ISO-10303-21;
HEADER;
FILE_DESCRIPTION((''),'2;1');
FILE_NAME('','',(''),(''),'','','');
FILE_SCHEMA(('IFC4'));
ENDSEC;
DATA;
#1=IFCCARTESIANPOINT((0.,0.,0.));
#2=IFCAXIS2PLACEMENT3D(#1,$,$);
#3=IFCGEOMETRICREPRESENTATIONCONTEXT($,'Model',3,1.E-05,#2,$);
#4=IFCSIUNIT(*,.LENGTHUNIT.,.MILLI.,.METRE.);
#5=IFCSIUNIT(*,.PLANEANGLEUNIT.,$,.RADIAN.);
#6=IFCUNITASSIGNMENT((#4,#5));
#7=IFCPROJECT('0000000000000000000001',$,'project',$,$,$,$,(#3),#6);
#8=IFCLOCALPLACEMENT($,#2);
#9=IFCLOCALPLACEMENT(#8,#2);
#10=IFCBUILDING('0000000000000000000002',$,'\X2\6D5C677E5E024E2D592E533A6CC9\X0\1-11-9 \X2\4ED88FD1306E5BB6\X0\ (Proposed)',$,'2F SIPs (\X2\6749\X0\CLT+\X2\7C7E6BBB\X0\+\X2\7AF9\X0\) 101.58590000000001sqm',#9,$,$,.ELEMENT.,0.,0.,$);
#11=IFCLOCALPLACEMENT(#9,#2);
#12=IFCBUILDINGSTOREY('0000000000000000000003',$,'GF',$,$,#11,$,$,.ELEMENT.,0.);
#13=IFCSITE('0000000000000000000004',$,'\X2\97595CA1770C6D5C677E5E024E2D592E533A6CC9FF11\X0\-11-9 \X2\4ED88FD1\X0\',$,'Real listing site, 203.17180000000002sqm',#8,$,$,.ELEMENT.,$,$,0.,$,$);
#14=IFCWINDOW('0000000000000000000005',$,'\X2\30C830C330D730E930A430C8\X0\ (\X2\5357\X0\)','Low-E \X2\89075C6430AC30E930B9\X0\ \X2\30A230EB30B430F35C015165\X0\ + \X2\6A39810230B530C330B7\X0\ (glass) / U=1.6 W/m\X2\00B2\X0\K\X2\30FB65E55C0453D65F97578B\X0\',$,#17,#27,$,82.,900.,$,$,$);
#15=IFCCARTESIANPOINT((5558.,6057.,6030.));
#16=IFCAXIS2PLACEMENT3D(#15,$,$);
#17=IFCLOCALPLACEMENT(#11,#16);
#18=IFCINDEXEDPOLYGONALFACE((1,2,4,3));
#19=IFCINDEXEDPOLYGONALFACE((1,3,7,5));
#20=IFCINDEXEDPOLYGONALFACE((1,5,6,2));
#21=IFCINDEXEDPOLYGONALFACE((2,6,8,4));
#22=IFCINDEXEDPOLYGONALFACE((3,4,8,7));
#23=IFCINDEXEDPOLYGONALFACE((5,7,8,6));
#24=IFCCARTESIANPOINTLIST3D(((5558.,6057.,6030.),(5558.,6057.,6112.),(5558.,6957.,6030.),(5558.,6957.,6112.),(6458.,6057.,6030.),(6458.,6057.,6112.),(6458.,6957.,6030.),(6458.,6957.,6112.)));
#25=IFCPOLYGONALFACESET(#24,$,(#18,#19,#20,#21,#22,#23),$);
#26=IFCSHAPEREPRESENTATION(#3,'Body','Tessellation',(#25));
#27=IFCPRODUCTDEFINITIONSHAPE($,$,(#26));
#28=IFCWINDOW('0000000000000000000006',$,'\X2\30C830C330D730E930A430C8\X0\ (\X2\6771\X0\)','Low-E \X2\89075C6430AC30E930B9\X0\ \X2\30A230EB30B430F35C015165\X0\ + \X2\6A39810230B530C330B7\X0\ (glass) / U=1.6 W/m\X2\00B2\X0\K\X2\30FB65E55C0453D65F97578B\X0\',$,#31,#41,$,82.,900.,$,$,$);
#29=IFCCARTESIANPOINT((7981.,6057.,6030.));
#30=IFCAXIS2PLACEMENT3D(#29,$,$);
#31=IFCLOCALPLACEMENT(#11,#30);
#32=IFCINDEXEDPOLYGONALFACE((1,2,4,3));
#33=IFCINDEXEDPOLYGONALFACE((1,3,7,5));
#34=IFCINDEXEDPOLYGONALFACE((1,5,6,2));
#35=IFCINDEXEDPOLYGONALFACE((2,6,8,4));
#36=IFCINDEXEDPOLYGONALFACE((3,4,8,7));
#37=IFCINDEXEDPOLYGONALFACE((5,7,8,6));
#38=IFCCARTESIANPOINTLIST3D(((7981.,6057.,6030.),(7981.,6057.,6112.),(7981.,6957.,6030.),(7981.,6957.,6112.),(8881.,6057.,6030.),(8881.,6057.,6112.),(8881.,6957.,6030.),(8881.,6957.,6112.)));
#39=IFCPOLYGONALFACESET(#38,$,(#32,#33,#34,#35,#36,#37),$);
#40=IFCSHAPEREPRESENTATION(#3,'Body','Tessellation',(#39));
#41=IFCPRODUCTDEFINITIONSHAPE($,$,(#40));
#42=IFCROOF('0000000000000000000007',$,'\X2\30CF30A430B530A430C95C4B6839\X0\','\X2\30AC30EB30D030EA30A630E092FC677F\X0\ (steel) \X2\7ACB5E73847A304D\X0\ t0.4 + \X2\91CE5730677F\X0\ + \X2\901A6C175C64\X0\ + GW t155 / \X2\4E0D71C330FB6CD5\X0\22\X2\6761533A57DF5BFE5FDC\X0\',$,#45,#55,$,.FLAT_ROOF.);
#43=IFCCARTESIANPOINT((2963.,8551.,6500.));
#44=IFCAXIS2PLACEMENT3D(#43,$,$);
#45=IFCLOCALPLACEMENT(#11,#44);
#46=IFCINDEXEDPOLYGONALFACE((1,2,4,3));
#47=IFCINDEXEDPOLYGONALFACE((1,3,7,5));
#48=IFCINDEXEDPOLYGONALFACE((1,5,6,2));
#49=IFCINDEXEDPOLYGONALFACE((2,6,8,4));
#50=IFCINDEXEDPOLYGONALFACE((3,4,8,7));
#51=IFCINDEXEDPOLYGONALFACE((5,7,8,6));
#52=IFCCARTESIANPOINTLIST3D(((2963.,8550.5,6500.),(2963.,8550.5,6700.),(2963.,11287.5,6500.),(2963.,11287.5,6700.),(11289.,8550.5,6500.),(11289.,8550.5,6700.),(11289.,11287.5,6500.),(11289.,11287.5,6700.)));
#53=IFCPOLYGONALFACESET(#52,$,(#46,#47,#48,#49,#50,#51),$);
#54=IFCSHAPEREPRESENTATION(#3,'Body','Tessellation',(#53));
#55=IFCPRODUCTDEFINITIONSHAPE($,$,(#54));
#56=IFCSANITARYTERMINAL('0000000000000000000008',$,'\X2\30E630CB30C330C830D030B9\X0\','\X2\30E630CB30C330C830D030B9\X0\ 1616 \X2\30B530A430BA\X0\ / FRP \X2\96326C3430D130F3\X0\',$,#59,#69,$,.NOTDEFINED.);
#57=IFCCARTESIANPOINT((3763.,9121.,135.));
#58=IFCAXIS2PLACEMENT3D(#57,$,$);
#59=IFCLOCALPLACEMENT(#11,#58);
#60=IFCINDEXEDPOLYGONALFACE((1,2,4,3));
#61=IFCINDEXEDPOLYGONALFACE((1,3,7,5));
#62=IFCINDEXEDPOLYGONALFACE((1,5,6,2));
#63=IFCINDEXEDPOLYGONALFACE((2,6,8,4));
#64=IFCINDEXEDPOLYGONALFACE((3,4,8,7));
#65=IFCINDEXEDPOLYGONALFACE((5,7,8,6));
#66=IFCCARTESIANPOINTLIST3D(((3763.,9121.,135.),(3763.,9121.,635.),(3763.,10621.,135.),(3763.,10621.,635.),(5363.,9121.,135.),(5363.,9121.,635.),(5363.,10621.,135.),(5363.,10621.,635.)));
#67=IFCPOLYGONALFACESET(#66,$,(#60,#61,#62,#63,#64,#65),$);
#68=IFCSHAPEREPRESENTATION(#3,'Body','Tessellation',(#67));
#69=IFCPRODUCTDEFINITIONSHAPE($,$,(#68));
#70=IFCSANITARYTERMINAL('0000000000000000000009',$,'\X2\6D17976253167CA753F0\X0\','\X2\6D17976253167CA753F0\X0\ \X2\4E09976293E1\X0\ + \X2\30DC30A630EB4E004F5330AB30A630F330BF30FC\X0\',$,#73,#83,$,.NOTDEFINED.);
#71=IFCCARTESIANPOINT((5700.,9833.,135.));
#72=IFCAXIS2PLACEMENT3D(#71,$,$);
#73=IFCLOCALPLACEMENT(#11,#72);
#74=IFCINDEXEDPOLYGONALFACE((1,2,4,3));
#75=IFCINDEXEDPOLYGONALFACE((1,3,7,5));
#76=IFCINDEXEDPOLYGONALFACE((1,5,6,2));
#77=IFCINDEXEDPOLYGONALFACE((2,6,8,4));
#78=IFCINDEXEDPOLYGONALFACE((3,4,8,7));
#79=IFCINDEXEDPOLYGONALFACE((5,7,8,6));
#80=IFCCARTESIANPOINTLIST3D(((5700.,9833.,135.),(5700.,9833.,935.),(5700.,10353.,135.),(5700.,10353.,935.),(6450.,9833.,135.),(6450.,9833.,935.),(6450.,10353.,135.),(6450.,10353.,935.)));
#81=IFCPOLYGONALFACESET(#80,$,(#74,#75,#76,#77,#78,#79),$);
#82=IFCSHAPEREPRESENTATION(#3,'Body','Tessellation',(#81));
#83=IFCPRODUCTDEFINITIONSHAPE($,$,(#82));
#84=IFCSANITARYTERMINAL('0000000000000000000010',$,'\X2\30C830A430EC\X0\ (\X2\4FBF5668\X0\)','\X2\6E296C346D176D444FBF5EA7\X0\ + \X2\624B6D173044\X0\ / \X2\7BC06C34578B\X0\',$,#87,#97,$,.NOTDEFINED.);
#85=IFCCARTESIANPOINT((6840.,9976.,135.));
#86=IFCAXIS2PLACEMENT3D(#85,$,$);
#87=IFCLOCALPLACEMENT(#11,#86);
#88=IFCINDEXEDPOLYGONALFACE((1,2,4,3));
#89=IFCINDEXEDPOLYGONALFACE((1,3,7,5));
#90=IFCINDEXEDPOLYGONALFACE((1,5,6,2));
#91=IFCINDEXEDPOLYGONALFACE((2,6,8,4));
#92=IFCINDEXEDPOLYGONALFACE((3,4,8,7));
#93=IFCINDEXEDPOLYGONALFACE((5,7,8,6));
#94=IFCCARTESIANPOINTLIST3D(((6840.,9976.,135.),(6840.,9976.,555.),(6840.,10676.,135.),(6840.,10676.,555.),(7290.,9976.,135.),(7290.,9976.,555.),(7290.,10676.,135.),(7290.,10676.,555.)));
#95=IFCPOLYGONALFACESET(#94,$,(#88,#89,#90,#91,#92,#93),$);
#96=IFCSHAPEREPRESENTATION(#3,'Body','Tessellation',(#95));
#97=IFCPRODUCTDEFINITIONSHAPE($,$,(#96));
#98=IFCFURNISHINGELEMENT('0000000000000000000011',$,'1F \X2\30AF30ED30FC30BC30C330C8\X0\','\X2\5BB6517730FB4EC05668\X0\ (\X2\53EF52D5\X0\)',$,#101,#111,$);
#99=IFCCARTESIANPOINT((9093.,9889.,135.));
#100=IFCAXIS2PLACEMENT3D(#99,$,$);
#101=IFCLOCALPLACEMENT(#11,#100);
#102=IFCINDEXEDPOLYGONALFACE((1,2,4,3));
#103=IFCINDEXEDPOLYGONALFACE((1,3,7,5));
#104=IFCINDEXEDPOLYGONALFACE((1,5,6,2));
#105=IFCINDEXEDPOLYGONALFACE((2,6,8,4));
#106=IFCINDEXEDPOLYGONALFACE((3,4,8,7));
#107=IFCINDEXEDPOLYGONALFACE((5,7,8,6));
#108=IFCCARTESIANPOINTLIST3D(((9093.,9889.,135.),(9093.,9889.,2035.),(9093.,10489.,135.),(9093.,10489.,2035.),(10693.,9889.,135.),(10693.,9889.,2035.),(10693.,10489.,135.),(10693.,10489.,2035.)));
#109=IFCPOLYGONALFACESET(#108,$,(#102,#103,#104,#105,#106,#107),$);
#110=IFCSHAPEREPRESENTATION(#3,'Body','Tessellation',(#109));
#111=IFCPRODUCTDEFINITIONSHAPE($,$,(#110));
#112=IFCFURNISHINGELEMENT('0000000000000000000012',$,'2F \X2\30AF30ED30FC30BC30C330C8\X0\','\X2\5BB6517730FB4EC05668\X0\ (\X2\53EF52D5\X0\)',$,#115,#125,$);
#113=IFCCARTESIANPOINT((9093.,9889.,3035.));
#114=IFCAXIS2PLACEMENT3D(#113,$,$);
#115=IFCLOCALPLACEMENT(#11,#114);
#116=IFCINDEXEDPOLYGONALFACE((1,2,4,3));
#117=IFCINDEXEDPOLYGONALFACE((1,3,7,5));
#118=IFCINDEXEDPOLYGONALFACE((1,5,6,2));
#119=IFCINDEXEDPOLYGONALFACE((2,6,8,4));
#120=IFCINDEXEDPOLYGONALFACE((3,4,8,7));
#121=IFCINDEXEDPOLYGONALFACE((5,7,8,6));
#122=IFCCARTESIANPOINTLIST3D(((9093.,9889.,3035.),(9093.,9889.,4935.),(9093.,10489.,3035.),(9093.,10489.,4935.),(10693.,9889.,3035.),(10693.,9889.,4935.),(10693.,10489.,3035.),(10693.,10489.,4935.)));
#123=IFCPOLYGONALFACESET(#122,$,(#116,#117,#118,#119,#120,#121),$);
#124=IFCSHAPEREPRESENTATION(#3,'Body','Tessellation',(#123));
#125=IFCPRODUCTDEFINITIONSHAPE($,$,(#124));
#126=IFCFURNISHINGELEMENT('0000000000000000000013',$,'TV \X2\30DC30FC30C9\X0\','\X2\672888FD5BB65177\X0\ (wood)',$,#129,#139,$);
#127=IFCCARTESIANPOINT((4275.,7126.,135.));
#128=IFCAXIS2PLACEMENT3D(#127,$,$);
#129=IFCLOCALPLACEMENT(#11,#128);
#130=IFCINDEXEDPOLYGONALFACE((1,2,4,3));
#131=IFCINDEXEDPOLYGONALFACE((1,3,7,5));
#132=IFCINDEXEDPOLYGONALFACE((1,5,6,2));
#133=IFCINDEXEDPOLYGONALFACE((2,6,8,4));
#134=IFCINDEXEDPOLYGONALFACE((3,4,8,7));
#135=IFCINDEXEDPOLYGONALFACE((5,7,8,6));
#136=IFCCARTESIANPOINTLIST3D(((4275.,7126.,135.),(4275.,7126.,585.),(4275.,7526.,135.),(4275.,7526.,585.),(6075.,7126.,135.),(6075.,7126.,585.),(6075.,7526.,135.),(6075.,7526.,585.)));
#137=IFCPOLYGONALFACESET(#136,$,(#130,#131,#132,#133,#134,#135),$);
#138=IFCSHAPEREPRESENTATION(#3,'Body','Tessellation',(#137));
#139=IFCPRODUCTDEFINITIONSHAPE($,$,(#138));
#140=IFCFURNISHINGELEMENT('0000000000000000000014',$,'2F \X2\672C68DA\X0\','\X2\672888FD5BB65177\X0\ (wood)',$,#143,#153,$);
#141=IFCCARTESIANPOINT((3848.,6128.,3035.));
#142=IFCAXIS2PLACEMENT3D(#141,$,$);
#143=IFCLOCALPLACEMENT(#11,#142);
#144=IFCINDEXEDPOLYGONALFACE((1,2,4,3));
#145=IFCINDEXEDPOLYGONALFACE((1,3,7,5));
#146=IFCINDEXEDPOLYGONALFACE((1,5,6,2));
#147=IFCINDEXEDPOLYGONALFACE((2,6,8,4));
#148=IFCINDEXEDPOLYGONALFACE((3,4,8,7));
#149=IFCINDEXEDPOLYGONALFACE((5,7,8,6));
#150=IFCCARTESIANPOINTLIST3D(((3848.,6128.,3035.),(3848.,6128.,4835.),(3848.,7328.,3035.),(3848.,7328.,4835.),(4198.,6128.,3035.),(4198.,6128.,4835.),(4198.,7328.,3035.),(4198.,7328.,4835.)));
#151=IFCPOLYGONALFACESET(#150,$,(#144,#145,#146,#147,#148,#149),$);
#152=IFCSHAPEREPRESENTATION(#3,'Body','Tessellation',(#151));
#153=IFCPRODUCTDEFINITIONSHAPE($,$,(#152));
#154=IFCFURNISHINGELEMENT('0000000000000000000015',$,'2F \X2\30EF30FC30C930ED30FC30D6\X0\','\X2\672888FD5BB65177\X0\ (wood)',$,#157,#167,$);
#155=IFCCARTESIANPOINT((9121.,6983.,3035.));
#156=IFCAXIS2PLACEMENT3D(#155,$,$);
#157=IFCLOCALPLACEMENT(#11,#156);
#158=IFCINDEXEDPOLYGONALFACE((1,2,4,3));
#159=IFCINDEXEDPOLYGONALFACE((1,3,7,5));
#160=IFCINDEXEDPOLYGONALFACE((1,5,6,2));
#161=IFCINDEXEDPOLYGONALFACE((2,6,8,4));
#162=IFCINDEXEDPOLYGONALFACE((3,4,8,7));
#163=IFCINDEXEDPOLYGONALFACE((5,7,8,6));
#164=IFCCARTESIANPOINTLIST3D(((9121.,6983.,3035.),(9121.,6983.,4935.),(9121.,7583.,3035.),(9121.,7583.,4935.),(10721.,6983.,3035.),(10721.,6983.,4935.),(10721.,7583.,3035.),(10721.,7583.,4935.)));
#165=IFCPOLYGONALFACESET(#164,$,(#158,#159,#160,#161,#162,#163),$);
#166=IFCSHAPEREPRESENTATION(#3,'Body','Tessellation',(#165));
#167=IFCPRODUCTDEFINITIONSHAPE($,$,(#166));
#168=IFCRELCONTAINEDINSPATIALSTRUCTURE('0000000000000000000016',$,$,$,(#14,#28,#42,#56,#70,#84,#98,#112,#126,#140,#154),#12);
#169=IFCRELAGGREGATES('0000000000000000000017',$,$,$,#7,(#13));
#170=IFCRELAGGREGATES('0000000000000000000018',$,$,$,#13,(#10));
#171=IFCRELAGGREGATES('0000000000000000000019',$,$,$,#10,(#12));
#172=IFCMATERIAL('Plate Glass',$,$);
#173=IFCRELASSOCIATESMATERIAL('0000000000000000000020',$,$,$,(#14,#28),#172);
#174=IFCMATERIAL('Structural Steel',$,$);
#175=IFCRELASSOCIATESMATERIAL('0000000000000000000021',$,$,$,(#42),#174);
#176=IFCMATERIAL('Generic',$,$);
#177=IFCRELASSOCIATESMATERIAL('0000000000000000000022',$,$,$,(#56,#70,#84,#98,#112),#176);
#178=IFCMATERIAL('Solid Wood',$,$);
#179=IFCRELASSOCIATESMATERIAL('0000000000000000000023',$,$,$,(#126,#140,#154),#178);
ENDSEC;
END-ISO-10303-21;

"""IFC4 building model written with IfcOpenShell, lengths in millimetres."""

from ifc_helpers import new_model, si_unit, frame, frame_2d, origin, place, context, project, spatial, rectangle, extrude, material, element, save


model = new_model("IFC4")

# Units and contexts
model_context = context("Model", 3, precision=1e-05, world=origin())
ifc_project = project(units=[si_unit("LENGTHUNIT", "METRE", prefix="MILLI"), si_unit("PLANEANGLEUNIT", "RADIAN")], contexts=[model_context])

# Site, building, storey
site_placement = place(None, origin())
site = spatial("IfcSite", under=ifc_project, at=site_placement, Name="静岡県浜松市中央区泉１-11-9 付近", ObjectType="Real listing site, 203.17180000000002sqm", CompositionType="ELEMENT", RefElevation=0.0)
building_placement = place(site_placement, origin())
building = spatial("IfcBuilding", under=site, at=building_placement, Name="浜松市中央区泉1-11-9 付近の家 (Proposed)", ObjectType="2F SIPs (杉CLT+籾殻+竹) 101.58590000000001sqm", CompositionType="ELEMENT", ElevationOfRefHeight=0.0, ElevationOfTerrain=0.0)
storey_placement = place(building_placement, origin())
storey = spatial("IfcBuildingStorey", under=building, at=storey_placement, Name="GF", CompositionType="ELEMENT", Elevation=0.0)

# Shared definitions
ifc_material_1 = material(Name="Solid Wood")
ifc_material_2 = material(Name="Plate Glass")

# Windows
window_1_placement = place(storey_placement, frame((5558.0, 6057.0, 6030.0)))
element("IfcWindow", 1, at=window_1_placement, inside=storey, material=ifc_material_2, Name="トップライト (南)", Description="Low-E 複層ガラス アルゴン封入 + 樹脂サッシ (glass) / U=1.6 W/m²K・日射取得型", OverallHeight=82.0, OverallWidth=900.0, context=model_context, shape_type="SweptSolid", body=[
    extrude(rectangle(XDim=900.0, YDim=900.0, at=frame_2d((450.0, 450.0))), frame((5558.0, 6057.0, 6030.0)), (0.0, 0.0, 1.0), 82.0),
])
window_2_placement = place(storey_placement, frame((7981.0, 6057.0, 6030.0)))
element("IfcWindow", 2, at=window_2_placement, inside=storey, material=ifc_material_2, Name="トップライト (東)", Description="Low-E 複層ガラス アルゴン封入 + 樹脂サッシ (glass) / U=1.6 W/m²K・日射取得型", OverallHeight=82.0, OverallWidth=900.0, context=model_context, shape_type="SweptSolid", body=[
    extrude(rectangle(XDim=900.0, YDim=900.0, at=frame_2d((450.0, 450.0))), frame((7981.0, 6057.0, 6030.0)), (0.0, 0.0, 1.0), 82.0),
])

# Roof
ifc_material_3 = material(Name="Structural Steel")
roof_placement = place(storey_placement, frame((2963.0, 8551.0, 6500.0)))
element("IfcRoof", 3, at=roof_placement, inside=storey, material=ifc_material_3, Name="ハイサイド屋根", Description="ガルバリウム鋼板 (steel) 立平葺き t0.4 + 野地板 + 通気層 + GW t155 / 不燃・法22条区域対応", PredefinedType="FLAT_ROOF", context=model_context, shape_type="SweptSolid", body=[
    extrude(rectangle(XDim=8326.0, YDim=2737.0, at=frame_2d((4163.0, 1368.0))), frame((2963.0, 8551.0, 6500.0)), (0.0, 0.0, 1.0), 200.0),
])

# Sanitary terminals
ifc_material_4 = material(Name="Generic")
sanitary_terminal_1_placement = place(storey_placement, frame((3763.0, 9121.0, 135.0)))
element("IfcSanitaryTerminal", 4, at=sanitary_terminal_1_placement, inside=storey, material=ifc_material_4, Name="ユニットバス", Description="ユニットバス 1616 サイズ / FRP 防水パン", PredefinedType="NOTDEFINED", context=model_context, shape_type="SweptSolid", body=[
    extrude(rectangle(XDim=1600.0, YDim=1500.0, at=frame_2d((800.0, 750.0))), frame((3763.0, 9121.0, 135.0)), (0.0, 0.0, 1.0), 500.0),
])
sanitary_terminal_2_placement = place(storey_placement, frame((5700.0, 9833.0, 135.0)))
element("IfcSanitaryTerminal", 5, at=sanitary_terminal_2_placement, inside=storey, material=ifc_material_4, Name="洗面化粧台", Description="洗面化粧台 三面鏡 + ボウル一体カウンター", PredefinedType="NOTDEFINED", context=model_context, shape_type="SweptSolid", body=[
    extrude(rectangle(XDim=750.0, YDim=520.0, at=frame_2d((375.0, 260.0))), frame((5700.0, 9833.0, 135.0)), (0.0, 0.0, 1.0), 800.0),
])
sanitary_terminal_3_placement = place(storey_placement, frame((6840.0, 9976.0, 135.0)))
element("IfcSanitaryTerminal", 6, at=sanitary_terminal_3_placement, inside=storey, material=ifc_material_4, Name="トイレ (便器)", Description="温水洗浄便座 + 手洗い / 節水型", PredefinedType="NOTDEFINED", context=model_context, shape_type="SweptSolid", body=[
    extrude(rectangle(XDim=450.0, YDim=700.0, at=frame_2d((225.0, 350.0))), frame((6840.0, 9976.0, 135.0)), (0.0, 0.0, 1.0), 420.0),
])

# Furnishing elements
furnishing_1_placement = place(storey_placement, frame((9093.0, 9889.0, 135.0)))
element("IfcFurnishingElement", 7, at=furnishing_1_placement, inside=storey, material=ifc_material_4, Name="1F クローゼット", Description="家具・什器 (可動)", context=model_context, shape_type="SweptSolid", body=[
    extrude(rectangle(XDim=1600.0, YDim=600.0, at=frame_2d((800.0, 300.0))), frame((9093.0, 9889.0, 135.0)), (0.0, 0.0, 1.0), 1900.0),
])
furnishing_2_placement = place(storey_placement, frame((9093.0, 9889.0, 3035.0)))
element("IfcFurnishingElement", 8, at=furnishing_2_placement, inside=storey, material=ifc_material_4, Name="2F クローゼット", Description="家具・什器 (可動)", context=model_context, shape_type="SweptSolid", body=[
    extrude(rectangle(XDim=1600.0, YDim=600.0, at=frame_2d((800.0, 300.0))), frame((9093.0, 9889.0, 3035.0)), (0.0, 0.0, 1.0), 1900.0),
])
furnishing_3_placement = place(storey_placement, frame((4275.0, 7126.0, 135.0)))
element("IfcFurnishingElement", 9, at=furnishing_3_placement, inside=storey, material=ifc_material_1, Name="TV ボード", Description="木製家具 (wood)", context=model_context, shape_type="SweptSolid", body=[
    extrude(rectangle(XDim=1800.0, YDim=400.0, at=frame_2d((900.0, 200.0))), frame((4275.0, 7126.0, 135.0)), (0.0, 0.0, 1.0), 450.0),
])
furnishing_4_placement = place(storey_placement, frame((3848.0, 6128.0, 3035.0)))
element("IfcFurnishingElement", 10, at=furnishing_4_placement, inside=storey, material=ifc_material_1, Name="2F 本棚", Description="木製家具 (wood)", context=model_context, shape_type="SweptSolid", body=[
    extrude(rectangle(XDim=350.0, YDim=1200.0, at=frame_2d((175.0, 600.0))), frame((3848.0, 6128.0, 3035.0)), (0.0, 0.0, 1.0), 1800.0),
])
furnishing_5_placement = place(storey_placement, frame((9121.0, 6983.0, 3035.0)))
element("IfcFurnishingElement", 11, at=furnishing_5_placement, inside=storey, material=ifc_material_1, Name="2F ワードローブ", Description="木製家具 (wood)", context=model_context, shape_type="SweptSolid", body=[
    extrude(rectangle(XDim=1600.0, YDim=600.0, at=frame_2d((800.0, 300.0))), frame((9121.0, 6983.0, 3035.0)), (0.0, 0.0, 1.0), 1900.0),
])

save(model, "model.ifc")
